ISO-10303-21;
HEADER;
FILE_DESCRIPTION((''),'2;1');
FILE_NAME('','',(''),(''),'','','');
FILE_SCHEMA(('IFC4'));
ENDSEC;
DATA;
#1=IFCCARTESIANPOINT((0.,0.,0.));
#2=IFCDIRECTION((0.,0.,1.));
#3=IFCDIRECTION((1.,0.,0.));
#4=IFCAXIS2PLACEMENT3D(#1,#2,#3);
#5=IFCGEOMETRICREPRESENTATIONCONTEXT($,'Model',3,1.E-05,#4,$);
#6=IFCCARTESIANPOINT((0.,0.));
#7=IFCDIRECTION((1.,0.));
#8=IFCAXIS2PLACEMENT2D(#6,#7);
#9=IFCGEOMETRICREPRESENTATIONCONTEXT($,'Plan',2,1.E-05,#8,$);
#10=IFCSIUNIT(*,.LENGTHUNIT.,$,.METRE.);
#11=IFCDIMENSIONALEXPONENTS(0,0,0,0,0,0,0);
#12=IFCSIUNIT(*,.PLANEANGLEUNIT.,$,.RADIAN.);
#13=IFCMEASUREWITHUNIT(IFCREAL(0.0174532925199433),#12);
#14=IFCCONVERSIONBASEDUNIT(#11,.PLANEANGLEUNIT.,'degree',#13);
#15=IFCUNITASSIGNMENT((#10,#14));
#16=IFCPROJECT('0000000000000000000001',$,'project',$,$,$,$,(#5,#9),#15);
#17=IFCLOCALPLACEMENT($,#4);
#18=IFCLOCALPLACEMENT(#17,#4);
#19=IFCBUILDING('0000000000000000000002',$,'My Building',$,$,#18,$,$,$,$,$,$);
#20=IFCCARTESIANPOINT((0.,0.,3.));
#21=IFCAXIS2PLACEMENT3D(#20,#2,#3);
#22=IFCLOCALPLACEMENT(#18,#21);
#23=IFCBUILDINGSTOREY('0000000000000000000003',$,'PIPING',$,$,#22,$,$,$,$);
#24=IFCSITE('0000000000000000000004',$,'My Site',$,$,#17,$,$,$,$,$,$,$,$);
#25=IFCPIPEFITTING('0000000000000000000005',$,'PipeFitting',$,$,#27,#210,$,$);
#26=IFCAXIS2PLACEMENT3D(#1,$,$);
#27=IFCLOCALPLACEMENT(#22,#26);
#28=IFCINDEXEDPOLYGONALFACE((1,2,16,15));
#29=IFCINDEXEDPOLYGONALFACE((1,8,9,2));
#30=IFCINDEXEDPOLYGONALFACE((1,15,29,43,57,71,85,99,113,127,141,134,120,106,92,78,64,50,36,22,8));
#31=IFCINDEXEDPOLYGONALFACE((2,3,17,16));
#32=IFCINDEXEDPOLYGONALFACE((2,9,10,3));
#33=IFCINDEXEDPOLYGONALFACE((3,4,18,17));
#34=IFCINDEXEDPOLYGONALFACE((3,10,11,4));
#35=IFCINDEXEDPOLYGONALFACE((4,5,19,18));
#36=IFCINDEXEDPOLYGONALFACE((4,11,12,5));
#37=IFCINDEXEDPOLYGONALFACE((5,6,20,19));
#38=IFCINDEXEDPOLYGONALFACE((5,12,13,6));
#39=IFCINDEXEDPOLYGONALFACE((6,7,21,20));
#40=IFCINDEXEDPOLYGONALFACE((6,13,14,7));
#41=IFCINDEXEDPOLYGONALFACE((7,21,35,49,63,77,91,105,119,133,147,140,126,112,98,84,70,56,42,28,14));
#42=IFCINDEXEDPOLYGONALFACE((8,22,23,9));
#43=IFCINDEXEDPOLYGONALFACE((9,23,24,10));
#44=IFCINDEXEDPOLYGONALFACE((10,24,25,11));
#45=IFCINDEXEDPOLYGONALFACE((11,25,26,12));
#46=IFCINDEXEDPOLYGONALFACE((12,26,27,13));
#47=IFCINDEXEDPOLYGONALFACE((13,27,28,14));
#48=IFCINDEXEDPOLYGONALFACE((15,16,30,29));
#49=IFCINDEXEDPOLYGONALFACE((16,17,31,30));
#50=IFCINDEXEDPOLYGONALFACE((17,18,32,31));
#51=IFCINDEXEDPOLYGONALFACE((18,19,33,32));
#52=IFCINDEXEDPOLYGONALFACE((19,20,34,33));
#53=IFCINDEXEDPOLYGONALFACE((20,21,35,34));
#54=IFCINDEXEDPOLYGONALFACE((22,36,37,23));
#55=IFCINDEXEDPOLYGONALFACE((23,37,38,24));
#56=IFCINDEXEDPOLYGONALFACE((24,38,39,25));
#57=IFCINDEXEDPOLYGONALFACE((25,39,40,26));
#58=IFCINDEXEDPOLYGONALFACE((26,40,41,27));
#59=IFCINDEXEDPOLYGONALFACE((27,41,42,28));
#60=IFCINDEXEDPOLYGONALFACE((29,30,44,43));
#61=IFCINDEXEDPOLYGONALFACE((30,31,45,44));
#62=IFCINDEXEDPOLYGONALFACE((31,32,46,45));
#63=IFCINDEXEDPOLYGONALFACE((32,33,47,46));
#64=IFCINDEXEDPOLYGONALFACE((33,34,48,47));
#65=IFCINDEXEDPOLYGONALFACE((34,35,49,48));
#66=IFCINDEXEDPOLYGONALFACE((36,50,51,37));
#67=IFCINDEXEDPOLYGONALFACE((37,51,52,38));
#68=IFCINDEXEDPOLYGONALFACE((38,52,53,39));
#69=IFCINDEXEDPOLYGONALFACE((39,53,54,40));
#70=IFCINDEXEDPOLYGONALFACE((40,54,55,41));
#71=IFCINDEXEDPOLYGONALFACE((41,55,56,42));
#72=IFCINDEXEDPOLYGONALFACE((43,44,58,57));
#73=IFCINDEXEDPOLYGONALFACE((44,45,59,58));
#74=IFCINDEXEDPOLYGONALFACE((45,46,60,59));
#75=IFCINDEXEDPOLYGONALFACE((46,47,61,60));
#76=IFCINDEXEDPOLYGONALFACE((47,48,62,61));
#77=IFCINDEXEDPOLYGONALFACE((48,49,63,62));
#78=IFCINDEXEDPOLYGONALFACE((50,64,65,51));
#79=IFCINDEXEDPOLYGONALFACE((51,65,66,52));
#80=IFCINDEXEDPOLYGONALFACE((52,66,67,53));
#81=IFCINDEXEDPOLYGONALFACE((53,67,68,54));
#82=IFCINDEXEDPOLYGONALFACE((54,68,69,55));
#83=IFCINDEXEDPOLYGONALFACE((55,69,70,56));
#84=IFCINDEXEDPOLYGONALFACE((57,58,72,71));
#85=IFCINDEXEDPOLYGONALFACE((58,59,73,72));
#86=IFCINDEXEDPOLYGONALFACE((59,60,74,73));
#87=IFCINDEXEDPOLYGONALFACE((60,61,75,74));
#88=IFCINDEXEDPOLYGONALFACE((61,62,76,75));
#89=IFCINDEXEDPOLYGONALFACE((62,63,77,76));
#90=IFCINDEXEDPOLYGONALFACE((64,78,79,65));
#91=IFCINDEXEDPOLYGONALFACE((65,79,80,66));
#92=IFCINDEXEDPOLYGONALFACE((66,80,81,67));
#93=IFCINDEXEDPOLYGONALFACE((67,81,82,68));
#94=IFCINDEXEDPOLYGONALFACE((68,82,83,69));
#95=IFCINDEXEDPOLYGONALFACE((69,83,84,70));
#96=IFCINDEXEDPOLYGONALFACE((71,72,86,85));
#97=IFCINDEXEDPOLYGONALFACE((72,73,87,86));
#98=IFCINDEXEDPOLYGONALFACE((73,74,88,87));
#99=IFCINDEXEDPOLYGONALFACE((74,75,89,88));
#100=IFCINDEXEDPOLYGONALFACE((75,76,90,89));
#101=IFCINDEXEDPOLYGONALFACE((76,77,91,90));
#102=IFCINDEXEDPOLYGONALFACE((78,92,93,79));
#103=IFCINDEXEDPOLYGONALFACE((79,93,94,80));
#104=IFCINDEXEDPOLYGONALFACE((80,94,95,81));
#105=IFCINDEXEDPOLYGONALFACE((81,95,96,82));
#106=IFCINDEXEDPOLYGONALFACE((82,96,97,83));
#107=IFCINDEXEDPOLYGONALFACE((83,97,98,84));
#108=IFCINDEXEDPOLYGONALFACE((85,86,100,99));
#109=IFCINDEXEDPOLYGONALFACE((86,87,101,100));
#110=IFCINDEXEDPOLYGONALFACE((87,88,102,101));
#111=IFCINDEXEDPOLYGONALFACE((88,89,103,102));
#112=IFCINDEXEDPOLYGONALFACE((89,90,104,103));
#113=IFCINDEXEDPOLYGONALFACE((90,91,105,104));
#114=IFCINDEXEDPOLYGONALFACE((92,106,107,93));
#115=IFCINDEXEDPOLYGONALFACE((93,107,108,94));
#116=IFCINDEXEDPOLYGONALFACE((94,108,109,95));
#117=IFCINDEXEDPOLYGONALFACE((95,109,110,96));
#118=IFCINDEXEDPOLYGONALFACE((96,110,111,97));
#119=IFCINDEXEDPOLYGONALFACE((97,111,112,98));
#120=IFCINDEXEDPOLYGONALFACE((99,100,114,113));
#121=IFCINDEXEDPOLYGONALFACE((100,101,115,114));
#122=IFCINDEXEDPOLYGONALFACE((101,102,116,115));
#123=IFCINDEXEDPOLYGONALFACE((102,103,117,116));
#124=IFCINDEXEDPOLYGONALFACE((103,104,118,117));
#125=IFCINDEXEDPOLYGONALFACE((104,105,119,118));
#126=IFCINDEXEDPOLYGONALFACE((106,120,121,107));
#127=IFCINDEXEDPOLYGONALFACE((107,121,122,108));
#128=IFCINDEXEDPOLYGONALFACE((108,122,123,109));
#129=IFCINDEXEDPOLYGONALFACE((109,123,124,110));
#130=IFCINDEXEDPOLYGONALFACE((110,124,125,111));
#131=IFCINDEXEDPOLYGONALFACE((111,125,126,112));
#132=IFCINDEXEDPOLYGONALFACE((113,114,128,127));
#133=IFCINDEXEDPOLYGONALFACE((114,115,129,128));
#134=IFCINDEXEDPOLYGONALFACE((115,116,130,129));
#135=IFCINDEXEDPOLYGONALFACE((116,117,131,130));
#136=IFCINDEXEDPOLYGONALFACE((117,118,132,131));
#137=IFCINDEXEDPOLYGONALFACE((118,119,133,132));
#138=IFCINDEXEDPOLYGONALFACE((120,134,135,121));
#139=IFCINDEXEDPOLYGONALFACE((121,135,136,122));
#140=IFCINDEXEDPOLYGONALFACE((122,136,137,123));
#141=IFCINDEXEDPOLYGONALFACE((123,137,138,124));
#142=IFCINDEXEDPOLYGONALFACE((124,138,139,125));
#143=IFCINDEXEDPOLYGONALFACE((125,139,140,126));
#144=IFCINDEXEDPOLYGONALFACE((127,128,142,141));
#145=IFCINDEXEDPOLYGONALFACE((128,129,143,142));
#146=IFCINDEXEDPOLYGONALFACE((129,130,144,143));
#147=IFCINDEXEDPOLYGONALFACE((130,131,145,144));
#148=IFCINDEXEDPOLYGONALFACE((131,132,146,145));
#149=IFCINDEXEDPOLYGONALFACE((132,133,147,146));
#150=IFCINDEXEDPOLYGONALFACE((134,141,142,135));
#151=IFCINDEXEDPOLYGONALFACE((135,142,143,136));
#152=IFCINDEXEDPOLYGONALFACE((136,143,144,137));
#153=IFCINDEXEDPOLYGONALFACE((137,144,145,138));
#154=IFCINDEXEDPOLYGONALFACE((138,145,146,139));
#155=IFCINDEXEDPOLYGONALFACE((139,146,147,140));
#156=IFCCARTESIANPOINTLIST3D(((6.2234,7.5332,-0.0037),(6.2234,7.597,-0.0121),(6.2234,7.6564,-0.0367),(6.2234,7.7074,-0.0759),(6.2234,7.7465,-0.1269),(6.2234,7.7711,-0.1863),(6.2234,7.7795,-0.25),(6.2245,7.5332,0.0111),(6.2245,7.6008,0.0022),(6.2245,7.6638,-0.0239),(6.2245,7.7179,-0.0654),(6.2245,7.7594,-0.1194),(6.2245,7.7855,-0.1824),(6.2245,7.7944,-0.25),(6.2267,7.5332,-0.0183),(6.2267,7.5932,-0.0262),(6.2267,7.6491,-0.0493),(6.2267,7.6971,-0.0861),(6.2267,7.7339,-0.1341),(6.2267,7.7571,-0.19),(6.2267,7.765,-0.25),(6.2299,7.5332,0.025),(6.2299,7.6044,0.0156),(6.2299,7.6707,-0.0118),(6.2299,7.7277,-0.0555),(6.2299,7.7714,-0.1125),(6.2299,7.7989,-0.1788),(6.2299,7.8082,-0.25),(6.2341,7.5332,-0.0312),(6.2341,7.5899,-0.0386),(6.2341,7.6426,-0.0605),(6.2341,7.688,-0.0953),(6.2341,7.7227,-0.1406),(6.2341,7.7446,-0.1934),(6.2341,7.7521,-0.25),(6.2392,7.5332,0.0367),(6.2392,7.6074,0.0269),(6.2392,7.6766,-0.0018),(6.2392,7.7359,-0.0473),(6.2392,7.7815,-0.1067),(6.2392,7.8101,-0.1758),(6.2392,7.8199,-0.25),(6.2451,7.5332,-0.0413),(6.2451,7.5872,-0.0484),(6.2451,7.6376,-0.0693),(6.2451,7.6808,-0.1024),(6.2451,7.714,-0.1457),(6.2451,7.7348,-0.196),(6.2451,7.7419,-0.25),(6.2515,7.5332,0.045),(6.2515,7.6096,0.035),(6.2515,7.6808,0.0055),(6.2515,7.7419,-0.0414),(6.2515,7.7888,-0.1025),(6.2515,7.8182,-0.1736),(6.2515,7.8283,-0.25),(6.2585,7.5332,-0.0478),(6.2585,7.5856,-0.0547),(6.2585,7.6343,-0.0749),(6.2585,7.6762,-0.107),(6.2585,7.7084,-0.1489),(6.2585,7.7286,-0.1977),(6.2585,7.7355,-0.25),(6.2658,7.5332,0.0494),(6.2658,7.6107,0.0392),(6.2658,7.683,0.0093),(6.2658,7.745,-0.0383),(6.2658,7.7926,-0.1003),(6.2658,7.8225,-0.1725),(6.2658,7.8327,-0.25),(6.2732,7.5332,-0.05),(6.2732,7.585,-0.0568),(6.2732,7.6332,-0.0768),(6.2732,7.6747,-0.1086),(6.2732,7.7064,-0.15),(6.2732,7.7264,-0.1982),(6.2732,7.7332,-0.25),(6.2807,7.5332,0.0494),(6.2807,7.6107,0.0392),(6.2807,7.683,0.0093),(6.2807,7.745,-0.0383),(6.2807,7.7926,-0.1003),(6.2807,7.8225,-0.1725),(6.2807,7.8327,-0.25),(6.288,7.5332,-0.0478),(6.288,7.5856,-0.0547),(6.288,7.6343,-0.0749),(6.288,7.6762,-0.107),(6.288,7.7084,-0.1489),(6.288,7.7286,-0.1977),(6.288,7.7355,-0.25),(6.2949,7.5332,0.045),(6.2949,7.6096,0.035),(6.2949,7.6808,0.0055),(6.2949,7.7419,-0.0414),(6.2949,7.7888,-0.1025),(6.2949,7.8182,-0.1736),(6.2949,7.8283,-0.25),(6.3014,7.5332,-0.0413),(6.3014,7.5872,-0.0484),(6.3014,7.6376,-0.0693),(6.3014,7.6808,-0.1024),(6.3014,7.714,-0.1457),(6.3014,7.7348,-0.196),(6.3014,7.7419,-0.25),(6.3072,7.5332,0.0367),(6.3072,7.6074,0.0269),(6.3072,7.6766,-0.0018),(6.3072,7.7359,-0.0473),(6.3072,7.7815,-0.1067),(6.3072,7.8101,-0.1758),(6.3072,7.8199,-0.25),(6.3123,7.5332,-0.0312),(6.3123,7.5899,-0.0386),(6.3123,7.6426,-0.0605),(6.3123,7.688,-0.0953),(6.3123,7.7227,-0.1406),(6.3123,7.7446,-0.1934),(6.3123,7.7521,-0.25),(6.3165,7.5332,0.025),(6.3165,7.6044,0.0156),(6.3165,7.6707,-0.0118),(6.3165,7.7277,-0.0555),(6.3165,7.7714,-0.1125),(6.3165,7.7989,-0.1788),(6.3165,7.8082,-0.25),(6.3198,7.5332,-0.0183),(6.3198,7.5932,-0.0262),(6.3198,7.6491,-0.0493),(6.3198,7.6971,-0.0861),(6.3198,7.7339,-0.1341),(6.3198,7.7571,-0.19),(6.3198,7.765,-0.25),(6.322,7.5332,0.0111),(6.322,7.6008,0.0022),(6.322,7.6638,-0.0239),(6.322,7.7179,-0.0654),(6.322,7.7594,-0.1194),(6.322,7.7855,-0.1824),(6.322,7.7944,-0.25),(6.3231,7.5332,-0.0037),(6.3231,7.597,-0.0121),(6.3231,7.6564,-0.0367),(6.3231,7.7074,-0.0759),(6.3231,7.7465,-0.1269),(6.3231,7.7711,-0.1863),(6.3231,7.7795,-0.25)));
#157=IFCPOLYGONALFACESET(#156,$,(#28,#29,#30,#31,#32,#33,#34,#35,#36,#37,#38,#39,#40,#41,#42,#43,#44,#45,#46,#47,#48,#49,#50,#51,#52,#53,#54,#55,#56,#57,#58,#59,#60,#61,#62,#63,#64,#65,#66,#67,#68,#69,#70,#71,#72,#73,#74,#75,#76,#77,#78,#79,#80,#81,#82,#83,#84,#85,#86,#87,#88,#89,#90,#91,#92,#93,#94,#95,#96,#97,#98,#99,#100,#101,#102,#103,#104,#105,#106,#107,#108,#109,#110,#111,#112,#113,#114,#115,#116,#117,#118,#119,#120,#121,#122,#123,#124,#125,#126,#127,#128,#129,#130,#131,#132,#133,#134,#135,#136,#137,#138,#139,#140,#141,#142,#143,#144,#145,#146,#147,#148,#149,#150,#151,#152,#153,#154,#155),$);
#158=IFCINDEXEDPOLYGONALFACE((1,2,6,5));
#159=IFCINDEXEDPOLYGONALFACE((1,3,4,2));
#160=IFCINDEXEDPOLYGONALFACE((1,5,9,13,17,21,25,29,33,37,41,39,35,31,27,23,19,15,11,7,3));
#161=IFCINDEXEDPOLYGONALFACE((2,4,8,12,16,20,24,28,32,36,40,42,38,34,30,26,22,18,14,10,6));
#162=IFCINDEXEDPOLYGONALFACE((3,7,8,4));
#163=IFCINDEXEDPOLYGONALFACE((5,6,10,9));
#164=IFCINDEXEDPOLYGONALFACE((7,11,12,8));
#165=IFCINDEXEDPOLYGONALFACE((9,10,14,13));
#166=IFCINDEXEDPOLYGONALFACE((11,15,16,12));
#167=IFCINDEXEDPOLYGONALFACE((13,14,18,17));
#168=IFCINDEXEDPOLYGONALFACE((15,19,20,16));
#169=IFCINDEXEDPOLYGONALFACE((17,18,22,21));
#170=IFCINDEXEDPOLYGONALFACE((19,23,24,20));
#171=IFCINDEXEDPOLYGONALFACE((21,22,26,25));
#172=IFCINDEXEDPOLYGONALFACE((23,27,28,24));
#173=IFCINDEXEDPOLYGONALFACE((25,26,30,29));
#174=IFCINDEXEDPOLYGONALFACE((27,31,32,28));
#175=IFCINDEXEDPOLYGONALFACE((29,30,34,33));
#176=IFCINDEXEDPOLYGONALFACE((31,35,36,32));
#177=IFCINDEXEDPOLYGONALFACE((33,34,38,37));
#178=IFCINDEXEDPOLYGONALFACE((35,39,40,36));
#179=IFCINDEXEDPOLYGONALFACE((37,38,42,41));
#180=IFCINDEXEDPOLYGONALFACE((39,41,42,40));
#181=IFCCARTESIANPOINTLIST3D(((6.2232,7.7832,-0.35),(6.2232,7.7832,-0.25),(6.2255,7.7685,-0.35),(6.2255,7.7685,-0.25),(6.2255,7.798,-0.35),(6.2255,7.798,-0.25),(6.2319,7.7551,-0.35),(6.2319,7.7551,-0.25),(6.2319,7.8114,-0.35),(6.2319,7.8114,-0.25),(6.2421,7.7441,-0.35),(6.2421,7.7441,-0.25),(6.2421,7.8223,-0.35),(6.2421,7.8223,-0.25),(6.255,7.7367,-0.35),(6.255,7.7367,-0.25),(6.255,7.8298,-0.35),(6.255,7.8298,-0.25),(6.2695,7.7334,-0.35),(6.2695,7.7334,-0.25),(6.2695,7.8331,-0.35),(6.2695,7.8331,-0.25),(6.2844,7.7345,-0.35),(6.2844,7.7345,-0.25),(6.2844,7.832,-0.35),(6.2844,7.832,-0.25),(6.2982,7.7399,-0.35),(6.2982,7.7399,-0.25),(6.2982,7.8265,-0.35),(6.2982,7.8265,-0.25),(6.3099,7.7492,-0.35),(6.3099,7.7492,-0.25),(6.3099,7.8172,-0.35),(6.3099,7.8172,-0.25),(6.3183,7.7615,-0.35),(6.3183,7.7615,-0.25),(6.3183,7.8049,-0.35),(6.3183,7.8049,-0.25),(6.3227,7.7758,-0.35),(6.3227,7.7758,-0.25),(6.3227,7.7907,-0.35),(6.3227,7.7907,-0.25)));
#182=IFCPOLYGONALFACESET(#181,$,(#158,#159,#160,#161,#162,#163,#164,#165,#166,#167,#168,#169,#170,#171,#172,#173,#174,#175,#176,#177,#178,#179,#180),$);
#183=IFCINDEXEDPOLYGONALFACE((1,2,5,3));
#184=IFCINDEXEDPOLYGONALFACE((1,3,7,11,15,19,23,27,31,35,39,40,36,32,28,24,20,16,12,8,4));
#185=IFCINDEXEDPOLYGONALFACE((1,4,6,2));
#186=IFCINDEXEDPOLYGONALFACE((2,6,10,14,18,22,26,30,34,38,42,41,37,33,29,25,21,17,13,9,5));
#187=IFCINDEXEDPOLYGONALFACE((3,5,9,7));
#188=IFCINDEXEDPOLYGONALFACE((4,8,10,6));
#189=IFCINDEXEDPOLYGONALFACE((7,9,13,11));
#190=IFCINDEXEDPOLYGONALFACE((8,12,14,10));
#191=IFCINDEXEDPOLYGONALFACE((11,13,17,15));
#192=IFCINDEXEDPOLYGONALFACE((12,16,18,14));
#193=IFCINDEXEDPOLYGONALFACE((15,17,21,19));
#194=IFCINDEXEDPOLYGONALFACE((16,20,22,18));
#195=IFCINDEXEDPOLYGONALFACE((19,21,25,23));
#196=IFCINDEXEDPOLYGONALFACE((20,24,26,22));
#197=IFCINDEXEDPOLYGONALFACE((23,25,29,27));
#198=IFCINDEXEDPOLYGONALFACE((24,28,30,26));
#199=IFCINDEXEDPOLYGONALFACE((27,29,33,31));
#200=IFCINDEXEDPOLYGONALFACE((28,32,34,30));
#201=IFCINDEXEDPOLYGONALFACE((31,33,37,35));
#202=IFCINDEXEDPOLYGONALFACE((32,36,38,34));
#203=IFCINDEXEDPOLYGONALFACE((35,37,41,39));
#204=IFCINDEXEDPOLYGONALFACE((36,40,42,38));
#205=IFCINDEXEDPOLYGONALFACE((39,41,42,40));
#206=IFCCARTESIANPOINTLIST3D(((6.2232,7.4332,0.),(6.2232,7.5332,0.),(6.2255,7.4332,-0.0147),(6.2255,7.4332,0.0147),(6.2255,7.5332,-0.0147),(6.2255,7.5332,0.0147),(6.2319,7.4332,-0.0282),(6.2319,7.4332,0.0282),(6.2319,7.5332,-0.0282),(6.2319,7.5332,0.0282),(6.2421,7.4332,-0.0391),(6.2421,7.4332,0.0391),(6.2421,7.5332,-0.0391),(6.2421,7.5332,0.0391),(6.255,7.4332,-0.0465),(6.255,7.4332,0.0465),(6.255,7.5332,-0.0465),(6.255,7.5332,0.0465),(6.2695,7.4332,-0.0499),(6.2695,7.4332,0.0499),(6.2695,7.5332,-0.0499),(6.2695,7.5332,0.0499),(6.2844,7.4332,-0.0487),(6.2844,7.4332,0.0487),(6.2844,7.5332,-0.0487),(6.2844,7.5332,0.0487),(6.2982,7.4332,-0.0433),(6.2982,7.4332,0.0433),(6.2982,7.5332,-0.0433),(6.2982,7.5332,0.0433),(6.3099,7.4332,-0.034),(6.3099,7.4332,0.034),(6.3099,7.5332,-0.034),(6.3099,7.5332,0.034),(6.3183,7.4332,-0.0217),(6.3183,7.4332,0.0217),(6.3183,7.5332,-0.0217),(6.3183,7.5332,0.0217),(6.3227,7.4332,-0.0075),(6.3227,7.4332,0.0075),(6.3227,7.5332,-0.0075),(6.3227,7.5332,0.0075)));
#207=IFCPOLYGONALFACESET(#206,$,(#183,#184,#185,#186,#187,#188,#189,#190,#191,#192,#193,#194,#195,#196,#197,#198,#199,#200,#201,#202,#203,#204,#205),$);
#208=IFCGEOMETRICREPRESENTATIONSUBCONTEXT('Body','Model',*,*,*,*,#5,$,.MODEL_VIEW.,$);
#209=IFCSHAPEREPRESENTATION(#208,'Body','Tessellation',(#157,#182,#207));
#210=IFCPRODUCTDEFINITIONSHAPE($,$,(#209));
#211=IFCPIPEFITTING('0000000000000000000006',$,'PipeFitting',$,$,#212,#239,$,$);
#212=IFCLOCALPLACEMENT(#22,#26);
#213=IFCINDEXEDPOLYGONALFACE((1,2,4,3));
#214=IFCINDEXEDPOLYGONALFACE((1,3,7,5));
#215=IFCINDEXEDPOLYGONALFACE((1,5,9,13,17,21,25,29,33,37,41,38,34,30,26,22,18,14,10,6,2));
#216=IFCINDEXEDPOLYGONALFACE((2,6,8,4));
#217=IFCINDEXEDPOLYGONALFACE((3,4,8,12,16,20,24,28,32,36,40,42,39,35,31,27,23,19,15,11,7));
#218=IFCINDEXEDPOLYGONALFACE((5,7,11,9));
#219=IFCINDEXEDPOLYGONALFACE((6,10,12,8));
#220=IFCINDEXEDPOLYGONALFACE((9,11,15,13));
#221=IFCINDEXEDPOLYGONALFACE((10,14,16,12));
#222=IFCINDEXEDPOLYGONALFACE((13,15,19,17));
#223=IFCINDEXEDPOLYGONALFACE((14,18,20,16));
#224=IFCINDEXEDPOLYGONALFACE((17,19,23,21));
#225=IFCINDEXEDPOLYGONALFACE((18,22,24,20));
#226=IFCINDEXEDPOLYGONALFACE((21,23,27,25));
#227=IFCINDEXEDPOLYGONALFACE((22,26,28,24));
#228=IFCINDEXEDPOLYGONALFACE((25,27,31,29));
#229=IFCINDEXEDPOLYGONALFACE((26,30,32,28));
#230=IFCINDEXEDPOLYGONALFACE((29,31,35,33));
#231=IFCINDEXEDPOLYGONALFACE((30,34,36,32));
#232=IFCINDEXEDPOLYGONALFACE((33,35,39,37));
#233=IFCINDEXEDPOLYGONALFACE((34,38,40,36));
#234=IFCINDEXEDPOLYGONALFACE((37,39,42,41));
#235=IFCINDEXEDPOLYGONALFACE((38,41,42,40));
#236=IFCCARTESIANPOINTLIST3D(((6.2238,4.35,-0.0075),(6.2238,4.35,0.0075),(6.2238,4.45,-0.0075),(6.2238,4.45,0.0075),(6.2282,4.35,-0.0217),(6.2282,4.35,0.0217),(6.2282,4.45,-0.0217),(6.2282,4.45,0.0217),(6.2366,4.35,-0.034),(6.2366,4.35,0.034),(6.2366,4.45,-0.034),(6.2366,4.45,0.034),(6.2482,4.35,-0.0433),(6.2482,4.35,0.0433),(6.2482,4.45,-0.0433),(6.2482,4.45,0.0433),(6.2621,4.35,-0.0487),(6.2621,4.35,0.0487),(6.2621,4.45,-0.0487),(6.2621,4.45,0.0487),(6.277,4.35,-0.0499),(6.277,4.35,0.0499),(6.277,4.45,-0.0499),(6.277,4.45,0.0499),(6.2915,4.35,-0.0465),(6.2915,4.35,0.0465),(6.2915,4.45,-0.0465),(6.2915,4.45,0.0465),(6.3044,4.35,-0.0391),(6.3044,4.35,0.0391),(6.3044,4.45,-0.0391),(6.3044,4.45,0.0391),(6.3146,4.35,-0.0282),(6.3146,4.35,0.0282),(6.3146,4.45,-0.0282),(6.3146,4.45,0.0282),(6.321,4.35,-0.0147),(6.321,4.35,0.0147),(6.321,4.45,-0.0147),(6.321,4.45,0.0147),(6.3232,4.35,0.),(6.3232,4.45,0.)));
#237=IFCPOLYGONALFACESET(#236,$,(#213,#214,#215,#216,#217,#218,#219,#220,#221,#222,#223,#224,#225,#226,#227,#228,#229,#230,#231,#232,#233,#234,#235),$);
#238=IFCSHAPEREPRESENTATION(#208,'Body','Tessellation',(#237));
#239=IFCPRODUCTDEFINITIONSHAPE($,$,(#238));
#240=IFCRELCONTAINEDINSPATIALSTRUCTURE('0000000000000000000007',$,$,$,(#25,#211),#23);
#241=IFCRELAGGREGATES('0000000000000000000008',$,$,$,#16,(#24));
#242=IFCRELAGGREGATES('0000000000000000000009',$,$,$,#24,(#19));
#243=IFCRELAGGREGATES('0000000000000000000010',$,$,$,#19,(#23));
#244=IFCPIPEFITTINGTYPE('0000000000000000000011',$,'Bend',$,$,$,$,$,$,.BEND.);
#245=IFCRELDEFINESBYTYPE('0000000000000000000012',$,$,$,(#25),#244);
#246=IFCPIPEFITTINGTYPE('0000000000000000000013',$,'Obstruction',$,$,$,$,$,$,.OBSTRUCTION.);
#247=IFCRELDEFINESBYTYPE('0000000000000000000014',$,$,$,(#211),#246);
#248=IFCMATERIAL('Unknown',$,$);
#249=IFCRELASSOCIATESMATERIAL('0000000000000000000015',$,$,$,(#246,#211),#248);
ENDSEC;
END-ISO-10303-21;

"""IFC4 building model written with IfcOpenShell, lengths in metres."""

from ifc_helpers import new_model, entity, si_unit, converted_unit, frame, origin_with_axes, origin_2d_with_axis, place, context, subcontext, project, spatial, circle, extrude, source, transform, mapped, material, material_profile, profile_set, profile_usage, type_object, type_shapes, element, save


model = new_model("IFC4")

# Units and contexts
model_context = context("Model", 3, precision=1e-05, world=origin_with_axes())
plan_context = context("Plan", 2, precision=1e-05, world=origin_2d_with_axis())
body_context = subcontext(model_context, "Body", "Model", "MODEL_VIEW")
ifc_project = project(units=[si_unit("LENGTHUNIT", "METRE"), converted_unit("PLANEANGLEUNIT", "degree", entity("IfcReal", 0.0174532925199433), si_unit("PLANEANGLEUNIT", "RADIAN"), dimensions=[0, 0, 0, 0, 0, 0, 0])], contexts=[model_context, plan_context])

# Site, building, storey
site_placement = place(None, origin_with_axes())
site = spatial("IfcSite", under=ifc_project, at=site_placement, Name="My Site")
building_placement = place(site_placement, origin_with_axes())
building = spatial("IfcBuilding", under=site, at=building_placement, Name="My Building")
storey_placement = place(building_placement, frame((0.0, 0.0, 3.0), z_axis=(0.0, 0.0, 1.0), x_axis=(1.0, 0.0, 0.0)))
storey = spatial("IfcBuildingStorey", under=building, at=storey_placement, Name="PIPING")

# Shared definitions
ifc_material = material(Name="Unknown")

# Pipe fittings
pipe_fitting_type_1 = type_object("IfcPipeFittingType", Name="Bend", PredefinedType="BEND")
shared_shape = source(origin_with_axes(), body_context, "Body", "SolidModel", [
    entity("IfcSweptDiskSolid", entity("IfcIndexedPolyCurve", entity("IfcCartesianPointList3D", [[0.0, 0.0, -0.1], [0.0, -0.0732, -0.2768], [0.0, -0.25, -0.35]]), [entity("IfcArcIndex", [1, 2, 3])]), 0.05),
    extrude(circle(Radius=0.05), origin_with_axes(), (0.0, 0.0, -1.0), 0.1),
    extrude(circle(Radius=0.05), frame((0.0, -0.25, -0.35), z_axis=(0.0, -1.0, 0.0), x_axis=(1.0, 0.0, 0.0)), (0.0, 0.0, 1.0), 0.1),
])
type_shapes(pipe_fitting_type_1, [shared_shape])
for number, where, z_axis, x_axis, name in (
    (1, (6.2732, 7.7832, -0.35), (0.0, 0.0, -1.0), (-1.0, 0.0, 0.0), "PipeFitting"),
):
    element("IfcPipeFitting", number, at=place(storey_placement, frame(where, z_axis=z_axis, x_axis=x_axis)), inside=storey, type_object=pipe_fitting_type_1, Name=name, context=body_context, shape_type="MappedRepresentation", body=[
        mapped(shared_shape, transform((0.0, 0.0, 0.0), x_axis=(1.0, 0.0, 0.0), y_axis=(0.0, 1.0, 0.0), z_axis=(0.0, 0.0, 1.0), scale=1.0)),
    ])
ifc_material_profile_1 = material_profile(ifc_material, circle(Radius=0.05))
ifc_profile_set_1 = profile_set([ifc_material_profile_1])
ifc_profile_usage_1 = profile_usage(ifc_profile_set_1, cardinal=5)
pipe_fitting_type_2 = type_object("IfcPipeFittingType", Name="Obstruction", PredefinedType="OBSTRUCTION", material=ifc_profile_set_1)
pipe_fitting_1_placement = place(storey_placement, frame((6.2732, 4.45, 0.0), z_axis=(0.0, -1.0, 0.0), x_axis=(1.0, 0.0, 0.0)))
element("IfcPipeFitting", 2, at=pipe_fitting_1_placement, inside=storey, type_object=pipe_fitting_type_2, material=ifc_profile_usage_1, Name="PipeFitting", context=body_context, shape_type="SweptSolid", body=[
    extrude(circle(Radius=0.05), origin_with_axes(), (0.0, 0.0, 1.0), 0.1),
])

save(model, "model.ifc")
